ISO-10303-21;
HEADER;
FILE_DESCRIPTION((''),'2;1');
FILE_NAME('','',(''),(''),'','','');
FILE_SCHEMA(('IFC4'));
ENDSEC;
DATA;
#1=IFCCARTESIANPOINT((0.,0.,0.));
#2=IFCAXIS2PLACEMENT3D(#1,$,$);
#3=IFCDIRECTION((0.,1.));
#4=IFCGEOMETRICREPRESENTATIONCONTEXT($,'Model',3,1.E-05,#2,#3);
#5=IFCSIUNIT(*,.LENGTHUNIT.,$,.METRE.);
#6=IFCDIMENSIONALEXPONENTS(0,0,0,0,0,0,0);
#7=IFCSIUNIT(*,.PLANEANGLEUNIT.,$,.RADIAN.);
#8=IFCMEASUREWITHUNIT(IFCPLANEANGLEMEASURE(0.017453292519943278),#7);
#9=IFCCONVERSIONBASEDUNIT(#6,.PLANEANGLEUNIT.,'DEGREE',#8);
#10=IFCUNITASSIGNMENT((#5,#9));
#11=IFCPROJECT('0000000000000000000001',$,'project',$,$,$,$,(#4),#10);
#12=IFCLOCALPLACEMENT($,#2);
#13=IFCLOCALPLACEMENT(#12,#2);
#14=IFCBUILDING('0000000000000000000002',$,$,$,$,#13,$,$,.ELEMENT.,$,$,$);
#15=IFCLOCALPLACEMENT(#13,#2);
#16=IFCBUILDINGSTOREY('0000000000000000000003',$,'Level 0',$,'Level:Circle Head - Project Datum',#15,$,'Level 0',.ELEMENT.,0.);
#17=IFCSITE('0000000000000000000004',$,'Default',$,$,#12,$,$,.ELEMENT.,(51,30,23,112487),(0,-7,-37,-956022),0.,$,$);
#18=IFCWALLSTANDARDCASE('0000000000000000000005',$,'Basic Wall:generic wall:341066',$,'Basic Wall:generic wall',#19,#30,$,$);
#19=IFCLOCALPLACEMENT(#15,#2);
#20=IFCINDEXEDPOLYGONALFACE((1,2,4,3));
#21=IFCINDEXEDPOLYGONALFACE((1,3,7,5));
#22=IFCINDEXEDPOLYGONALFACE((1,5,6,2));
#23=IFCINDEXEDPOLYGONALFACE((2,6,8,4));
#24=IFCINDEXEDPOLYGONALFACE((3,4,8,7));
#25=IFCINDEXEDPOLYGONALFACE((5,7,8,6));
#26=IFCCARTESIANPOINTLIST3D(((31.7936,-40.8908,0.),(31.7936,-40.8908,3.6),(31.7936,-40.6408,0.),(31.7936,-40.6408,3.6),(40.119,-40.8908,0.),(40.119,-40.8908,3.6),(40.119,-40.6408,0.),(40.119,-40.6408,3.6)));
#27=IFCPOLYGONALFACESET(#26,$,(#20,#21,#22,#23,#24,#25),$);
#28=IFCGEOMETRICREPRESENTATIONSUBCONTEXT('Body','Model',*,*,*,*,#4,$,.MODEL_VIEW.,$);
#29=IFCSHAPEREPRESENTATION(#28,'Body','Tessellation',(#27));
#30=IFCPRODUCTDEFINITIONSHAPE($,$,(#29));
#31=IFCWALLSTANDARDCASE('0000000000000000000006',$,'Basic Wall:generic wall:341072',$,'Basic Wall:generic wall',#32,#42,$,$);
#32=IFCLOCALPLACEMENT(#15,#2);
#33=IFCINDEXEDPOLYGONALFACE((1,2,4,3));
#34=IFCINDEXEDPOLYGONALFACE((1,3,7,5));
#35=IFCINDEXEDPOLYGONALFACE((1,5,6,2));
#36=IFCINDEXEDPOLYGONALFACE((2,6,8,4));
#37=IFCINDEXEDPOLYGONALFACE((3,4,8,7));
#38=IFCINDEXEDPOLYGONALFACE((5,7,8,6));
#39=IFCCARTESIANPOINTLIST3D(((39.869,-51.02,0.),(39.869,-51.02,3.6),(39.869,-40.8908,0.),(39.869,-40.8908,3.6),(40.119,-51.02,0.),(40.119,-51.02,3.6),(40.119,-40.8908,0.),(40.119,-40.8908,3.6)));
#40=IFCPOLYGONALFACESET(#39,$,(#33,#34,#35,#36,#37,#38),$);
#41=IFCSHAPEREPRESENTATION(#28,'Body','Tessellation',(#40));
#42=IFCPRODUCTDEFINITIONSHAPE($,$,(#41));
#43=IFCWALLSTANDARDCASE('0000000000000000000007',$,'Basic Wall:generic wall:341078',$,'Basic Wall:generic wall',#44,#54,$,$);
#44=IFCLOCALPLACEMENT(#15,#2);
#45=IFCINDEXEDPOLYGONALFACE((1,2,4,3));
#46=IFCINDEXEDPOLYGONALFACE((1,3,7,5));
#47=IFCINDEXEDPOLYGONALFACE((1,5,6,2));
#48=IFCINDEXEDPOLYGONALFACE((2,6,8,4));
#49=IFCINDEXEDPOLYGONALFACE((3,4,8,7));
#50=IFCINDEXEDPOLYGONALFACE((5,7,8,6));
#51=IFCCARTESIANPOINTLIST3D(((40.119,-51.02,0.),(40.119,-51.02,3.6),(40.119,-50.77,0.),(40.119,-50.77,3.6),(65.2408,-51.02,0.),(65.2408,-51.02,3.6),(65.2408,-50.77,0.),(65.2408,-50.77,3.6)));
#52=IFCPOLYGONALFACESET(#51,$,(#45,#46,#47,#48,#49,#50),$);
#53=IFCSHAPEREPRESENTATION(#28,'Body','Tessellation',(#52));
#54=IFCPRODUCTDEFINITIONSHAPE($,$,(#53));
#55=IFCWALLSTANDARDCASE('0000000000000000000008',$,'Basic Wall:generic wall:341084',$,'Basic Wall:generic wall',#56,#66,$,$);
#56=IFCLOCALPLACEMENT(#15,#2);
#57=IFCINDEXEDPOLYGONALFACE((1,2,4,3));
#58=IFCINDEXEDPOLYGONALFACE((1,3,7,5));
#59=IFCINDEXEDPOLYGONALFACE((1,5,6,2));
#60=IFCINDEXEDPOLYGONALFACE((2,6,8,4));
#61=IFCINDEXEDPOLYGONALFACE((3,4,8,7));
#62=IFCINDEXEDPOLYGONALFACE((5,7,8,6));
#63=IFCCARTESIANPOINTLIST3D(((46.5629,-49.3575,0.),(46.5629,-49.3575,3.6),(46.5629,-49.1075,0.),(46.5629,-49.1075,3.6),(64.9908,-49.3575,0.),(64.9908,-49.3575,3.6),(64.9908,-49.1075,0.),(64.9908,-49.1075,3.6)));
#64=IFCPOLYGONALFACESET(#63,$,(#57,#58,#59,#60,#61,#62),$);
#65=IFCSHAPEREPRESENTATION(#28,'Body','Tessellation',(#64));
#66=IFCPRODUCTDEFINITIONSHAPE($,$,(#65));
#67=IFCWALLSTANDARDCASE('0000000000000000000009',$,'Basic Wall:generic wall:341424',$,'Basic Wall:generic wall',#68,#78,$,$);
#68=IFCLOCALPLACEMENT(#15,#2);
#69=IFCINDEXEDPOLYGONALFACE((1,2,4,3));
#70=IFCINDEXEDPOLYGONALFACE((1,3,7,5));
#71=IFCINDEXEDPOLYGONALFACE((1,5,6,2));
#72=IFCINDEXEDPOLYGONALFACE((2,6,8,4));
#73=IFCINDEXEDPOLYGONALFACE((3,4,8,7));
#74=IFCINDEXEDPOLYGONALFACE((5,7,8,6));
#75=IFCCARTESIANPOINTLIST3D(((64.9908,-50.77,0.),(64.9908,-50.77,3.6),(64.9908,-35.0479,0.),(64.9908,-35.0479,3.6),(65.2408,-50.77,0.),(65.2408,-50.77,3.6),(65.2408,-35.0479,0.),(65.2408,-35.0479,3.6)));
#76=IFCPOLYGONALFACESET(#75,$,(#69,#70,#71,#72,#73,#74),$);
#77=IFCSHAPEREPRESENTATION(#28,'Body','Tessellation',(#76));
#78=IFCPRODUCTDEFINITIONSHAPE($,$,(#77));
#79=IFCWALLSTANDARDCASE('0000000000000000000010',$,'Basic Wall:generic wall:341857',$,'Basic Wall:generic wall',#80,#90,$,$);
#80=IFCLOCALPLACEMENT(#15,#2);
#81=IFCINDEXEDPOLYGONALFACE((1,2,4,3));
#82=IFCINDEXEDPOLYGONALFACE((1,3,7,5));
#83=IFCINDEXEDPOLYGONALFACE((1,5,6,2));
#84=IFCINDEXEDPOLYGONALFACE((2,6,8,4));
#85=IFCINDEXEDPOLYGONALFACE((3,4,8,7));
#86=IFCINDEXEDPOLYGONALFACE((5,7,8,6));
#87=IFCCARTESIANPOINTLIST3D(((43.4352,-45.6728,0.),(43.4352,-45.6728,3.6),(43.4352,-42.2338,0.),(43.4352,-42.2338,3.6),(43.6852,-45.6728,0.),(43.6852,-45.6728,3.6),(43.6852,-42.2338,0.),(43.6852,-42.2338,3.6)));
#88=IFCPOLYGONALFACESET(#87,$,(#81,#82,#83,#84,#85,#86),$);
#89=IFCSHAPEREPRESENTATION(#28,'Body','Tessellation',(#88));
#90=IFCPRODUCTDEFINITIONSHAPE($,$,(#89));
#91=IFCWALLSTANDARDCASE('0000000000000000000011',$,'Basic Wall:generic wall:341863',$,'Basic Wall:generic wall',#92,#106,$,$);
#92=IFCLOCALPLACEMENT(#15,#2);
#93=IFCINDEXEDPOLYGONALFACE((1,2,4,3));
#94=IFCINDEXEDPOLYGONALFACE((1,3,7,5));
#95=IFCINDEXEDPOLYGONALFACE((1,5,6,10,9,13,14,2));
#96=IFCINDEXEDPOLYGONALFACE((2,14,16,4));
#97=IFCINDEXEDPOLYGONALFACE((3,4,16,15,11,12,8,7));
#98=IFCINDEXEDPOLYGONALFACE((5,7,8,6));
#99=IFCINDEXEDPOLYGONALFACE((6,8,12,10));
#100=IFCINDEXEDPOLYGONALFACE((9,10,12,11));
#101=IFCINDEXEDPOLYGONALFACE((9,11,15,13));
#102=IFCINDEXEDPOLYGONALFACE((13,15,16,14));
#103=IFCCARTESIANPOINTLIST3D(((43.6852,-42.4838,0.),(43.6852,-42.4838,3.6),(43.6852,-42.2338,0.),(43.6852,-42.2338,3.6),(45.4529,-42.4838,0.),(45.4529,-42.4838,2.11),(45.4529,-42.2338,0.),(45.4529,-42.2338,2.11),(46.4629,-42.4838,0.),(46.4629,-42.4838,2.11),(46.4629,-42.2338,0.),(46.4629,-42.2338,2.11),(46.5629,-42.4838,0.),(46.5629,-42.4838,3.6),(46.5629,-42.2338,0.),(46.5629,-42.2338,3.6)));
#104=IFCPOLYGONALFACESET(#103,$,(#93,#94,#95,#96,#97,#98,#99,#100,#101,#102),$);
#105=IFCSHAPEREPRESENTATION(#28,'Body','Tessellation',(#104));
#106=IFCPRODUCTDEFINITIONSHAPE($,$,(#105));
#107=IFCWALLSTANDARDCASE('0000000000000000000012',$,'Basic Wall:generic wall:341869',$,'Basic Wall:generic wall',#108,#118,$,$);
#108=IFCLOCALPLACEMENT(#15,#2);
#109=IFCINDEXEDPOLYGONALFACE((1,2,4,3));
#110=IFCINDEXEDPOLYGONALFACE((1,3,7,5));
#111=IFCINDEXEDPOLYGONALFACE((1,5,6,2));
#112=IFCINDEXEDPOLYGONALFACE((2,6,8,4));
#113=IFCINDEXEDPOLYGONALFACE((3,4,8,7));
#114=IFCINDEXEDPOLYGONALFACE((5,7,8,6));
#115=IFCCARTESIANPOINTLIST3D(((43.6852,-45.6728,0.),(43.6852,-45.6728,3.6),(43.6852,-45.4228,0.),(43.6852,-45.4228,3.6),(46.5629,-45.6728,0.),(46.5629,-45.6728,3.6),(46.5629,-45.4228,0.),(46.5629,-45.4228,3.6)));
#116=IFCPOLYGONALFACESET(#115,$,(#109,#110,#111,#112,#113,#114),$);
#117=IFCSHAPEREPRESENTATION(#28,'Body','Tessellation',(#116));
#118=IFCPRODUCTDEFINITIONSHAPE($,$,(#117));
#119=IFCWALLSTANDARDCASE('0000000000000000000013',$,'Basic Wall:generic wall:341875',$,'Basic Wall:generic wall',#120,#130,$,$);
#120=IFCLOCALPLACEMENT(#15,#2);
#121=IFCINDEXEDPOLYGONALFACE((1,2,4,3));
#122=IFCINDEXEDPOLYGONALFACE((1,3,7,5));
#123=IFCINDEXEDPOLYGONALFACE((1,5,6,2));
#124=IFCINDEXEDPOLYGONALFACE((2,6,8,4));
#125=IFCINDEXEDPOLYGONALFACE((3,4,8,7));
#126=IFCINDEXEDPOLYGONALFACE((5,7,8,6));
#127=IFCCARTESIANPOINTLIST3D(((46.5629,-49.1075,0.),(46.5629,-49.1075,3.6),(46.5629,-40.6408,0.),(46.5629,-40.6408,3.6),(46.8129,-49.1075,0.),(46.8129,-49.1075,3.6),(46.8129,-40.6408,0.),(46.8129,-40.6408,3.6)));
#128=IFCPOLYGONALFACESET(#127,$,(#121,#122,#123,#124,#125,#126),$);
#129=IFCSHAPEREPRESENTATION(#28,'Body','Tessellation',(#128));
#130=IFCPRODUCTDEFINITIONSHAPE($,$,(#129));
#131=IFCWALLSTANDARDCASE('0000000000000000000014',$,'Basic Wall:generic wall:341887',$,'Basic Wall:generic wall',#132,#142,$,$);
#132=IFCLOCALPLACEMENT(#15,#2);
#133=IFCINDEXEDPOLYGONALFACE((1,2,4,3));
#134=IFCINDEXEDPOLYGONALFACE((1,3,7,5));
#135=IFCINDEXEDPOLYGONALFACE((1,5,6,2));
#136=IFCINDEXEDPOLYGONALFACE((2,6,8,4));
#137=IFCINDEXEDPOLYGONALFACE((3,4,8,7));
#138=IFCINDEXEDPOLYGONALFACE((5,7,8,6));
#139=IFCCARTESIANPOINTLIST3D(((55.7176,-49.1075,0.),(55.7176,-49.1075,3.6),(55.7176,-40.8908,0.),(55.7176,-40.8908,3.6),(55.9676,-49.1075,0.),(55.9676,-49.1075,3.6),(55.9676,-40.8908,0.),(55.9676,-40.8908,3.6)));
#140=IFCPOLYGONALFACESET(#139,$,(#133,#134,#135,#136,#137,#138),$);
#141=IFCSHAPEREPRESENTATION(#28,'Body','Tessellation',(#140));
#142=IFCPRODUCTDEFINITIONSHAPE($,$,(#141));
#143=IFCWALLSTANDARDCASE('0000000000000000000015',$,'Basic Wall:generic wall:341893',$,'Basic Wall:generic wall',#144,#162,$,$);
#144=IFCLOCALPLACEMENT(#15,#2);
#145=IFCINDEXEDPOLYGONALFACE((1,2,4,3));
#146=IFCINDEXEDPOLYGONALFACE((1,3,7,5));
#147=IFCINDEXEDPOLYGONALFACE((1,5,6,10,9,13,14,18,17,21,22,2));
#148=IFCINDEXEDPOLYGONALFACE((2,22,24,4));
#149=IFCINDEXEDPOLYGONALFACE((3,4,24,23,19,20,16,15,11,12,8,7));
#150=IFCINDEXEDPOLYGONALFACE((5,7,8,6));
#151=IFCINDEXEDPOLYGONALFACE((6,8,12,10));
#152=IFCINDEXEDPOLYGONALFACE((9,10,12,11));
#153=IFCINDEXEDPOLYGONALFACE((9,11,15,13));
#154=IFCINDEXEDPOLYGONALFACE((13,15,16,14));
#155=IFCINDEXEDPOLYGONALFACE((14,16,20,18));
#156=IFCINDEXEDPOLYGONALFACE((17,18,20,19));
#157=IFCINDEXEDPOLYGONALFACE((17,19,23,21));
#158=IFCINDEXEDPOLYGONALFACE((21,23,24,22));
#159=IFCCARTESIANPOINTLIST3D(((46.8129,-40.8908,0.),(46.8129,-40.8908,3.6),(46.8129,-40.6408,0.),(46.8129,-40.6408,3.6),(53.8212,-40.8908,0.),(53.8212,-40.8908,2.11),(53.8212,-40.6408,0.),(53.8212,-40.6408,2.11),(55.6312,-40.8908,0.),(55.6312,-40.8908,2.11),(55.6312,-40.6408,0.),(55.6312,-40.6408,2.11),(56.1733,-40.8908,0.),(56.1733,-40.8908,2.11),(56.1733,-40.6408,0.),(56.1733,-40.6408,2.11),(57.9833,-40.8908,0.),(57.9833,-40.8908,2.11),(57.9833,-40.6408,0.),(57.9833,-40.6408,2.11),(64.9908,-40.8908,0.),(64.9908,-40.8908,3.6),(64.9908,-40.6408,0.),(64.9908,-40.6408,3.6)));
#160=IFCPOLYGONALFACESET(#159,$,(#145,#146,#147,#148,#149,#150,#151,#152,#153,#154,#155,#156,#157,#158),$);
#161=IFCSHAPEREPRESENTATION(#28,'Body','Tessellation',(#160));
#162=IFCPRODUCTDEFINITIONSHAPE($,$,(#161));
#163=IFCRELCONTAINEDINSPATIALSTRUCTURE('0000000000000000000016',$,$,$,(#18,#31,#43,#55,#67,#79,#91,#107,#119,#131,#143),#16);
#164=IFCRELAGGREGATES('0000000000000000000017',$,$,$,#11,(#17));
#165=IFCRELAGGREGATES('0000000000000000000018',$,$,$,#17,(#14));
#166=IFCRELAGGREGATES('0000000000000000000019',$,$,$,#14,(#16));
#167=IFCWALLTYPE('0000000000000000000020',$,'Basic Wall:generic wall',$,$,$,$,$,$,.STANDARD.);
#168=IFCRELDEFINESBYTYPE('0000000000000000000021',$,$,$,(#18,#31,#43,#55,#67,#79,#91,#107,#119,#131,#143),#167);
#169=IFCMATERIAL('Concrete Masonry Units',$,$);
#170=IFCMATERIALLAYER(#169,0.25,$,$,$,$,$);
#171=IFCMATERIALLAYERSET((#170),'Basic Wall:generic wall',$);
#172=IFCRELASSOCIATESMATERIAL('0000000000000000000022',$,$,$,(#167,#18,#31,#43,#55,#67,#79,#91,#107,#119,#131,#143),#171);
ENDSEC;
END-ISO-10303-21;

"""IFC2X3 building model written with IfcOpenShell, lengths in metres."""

from ifc_helpers import new_model, entity, si_unit, converted_unit, direction, frame, frame_2d, origin, place, context, subcontext, project, spatial, rectangle, extrude, material, layer, layer_set, layer_usage, type_object, element, save


model = new_model("IFC2X3")

# Units and contexts
model_context = context("Model", 3, precision=1e-05, world=origin(), true_north=direction((0.0, 1.0)))
body_context = subcontext(model_context, "Body", "Model", "MODEL_VIEW")
ifc_project = project(units=[si_unit("LENGTHUNIT", "METRE"), converted_unit("PLANEANGLEUNIT", "DEGREE", entity("IfcPlaneAngleMeasure", 0.017453292519943278), si_unit("PLANEANGLEUNIT", "RADIAN"), dimensions=[0, 0, 0, 0, 0, 0, 0])], contexts=[model_context])

# Site, building, storey
site_placement = place(None, origin())
site = spatial("IfcSite", under=ifc_project, at=site_placement, Name="Default", CompositionType="ELEMENT", RefLatitude=(51, 30, 23, 112487), RefLongitude=(0, -7, -37, -956022), RefElevation=0.0)
building_placement = place(site_placement, origin())
building = spatial("IfcBuilding", under=site, at=building_placement, CompositionType="ELEMENT")
storey_placement = place(building_placement, origin())
storey = spatial("IfcBuildingStorey", under=building, at=storey_placement, Name="Level 0", ObjectType="Level:Circle Head - Project Datum", LongName="Level 0", CompositionType="ELEMENT", Elevation=0.0)

# Walls
ifc_material = material(Name="Concrete Masonry Units")
ifc_layer = layer(ifc_material, 0.25)
ifc_layer_set = layer_set([ifc_layer], Name="Basic Wall:generic wall")
ifc_layer_usage_1 = layer_usage(ifc_layer_set, "AXIS2", "NEGATIVE", 0.125)
wall_type = type_object("IfcWallType", Name="Basic Wall:generic wall", PredefinedType="STANDARD", material=ifc_layer_set)
wall_1_placement = place(storey_placement, frame((31.7936, -40.7658, 0.0)))
element("IfcWallStandardCase", 1, at=wall_1_placement, inside=storey, type_object=wall_type, material=ifc_layer_usage_1, Name="Basic Wall:generic wall:341066", ObjectType="Basic Wall:generic wall", context=body_context, shape_type="SweptSolid", body=[
    extrude(rectangle(XDim=8.3254, YDim=0.25, at=frame_2d((4.1627, 0.0), x_axis=(-1.0, 0.0))), origin(), (0.0, 0.0, 1.0), 3.6),
])
ifc_layer_usage_2 = layer_usage(ifc_layer_set, "AXIS2", "NEGATIVE", 0.125)
wall_2_placement = place(storey_placement, frame((39.994, -40.8908, 0.0), z_axis=(0.0, 0.0, 1.0), x_axis=(0.0, -1.0, 0.0)))
element("IfcWallStandardCase", 2, at=wall_2_placement, inside=storey, type_object=wall_type, material=ifc_layer_usage_2, Name="Basic Wall:generic wall:341072", ObjectType="Basic Wall:generic wall", context=body_context, shape_type="SweptSolid", body=[
    extrude(rectangle(XDim=10.1292, YDim=0.25, at=frame_2d((5.0646, 0.0), x_axis=(-1.0, 0.0))), origin(), (0.0, 0.0, 1.0), 3.6),
])
ifc_layer_usage_3 = layer_usage(ifc_layer_set, "AXIS2", "NEGATIVE", 0.125)
wall_3_placement = place(storey_placement, frame((40.119, -50.895, 0.0)))
element("IfcWallStandardCase", 3, at=wall_3_placement, inside=storey, type_object=wall_type, material=ifc_layer_usage_3, Name="Basic Wall:generic wall:341078", ObjectType="Basic Wall:generic wall", context=body_context, shape_type="SweptSolid", body=[
    extrude(rectangle(XDim=25.1218, YDim=0.25, at=frame_2d((12.5609, 0.0), x_axis=(-1.0, 0.0))), origin(), (0.0, 0.0, 1.0), 3.6),
])
ifc_layer_usage_4 = layer_usage(ifc_layer_set, "AXIS2", "NEGATIVE", 0.125)
wall_4_placement = place(storey_placement, frame((64.9908, -49.2325, 0.0), z_axis=(0.0, 0.0, 1.0), x_axis=(-1.0, 0.0, 0.0)))
element("IfcWallStandardCase", 4, at=wall_4_placement, inside=storey, type_object=wall_type, material=ifc_layer_usage_4, Name="Basic Wall:generic wall:341084", ObjectType="Basic Wall:generic wall", context=body_context, shape_type="SweptSolid", body=[
    extrude(rectangle(XDim=18.4279, YDim=0.25, at=frame_2d((9.2139, 0.0), x_axis=(-1.0, 0.0))), origin(), (0.0, 0.0, 1.0), 3.6),
])
ifc_layer_usage_5 = layer_usage(ifc_layer_set, "AXIS2", "NEGATIVE", 0.125)
wall_5_placement = place(storey_placement, frame((65.1158, -50.77, 0.0), z_axis=(0.0, 0.0, 1.0), x_axis=(0.0, 1.0, 0.0)))
element("IfcWallStandardCase", 5, at=wall_5_placement, inside=storey, type_object=wall_type, material=ifc_layer_usage_5, Name="Basic Wall:generic wall:341424", ObjectType="Basic Wall:generic wall", context=body_context, shape_type="SweptSolid", body=[
    extrude(rectangle(XDim=15.7221, YDim=0.25, at=frame_2d((7.861, 0.0), x_axis=(-1.0, 0.0))), origin(), (0.0, 0.0, 1.0), 3.6),
])
ifc_layer_usage_6 = layer_usage(ifc_layer_set, "AXIS2", "NEGATIVE", 0.125)
wall_6_placement = place(storey_placement, frame((43.5602, -45.6728, 0.0), z_axis=(0.0, 0.0, 1.0), x_axis=(0.0, 1.0, 0.0)))
element("IfcWallStandardCase", 6, at=wall_6_placement, inside=storey, type_object=wall_type, material=ifc_layer_usage_6, Name="Basic Wall:generic wall:341857", ObjectType="Basic Wall:generic wall", context=body_context, shape_type="SweptSolid", body=[
    extrude(rectangle(XDim=3.4391, YDim=0.25, at=frame_2d((1.7195, 0.0), x_axis=(-1.0, 0.0))), origin(), (0.0, 0.0, 1.0), 3.6),
])

# Wall, opening
ifc_layer_usage_7 = layer_usage(ifc_layer_set, "AXIS2", "NEGATIVE", 0.125)
wall_7_placement = place(storey_placement, frame((43.6852, -42.3588, 0.0)))
wall_7 = element("IfcWallStandardCase", 7, at=wall_7_placement, inside=storey, type_object=wall_type, material=ifc_layer_usage_7, Name="Basic Wall:generic wall:341863", ObjectType="Basic Wall:generic wall", context=body_context, shape_type="SweptSolid", body=[
    extrude(rectangle(XDim=2.8776, YDim=0.25, at=frame_2d((1.4388, 0.0), x_axis=(1.0, 0.0))), origin(), (0.0, 0.0, 1.0), 3.6),
])
opening_1_placement = place(wall_7_placement, frame((2.7776, 0.125, 0.0)))
element("IfcOpeningElement", 8, at=opening_1_placement, cuts=wall_7, ObjectType="Opening", context=body_context, shape_type="SweptSolid", body=[
    extrude(rectangle(XDim=2.11, YDim=1.01, at=frame_2d((1.055, 0.505), x_axis=(1.0, 0.0))), frame((0.0, 0.0, 0.0), z_axis=(0.0, -1.0, 0.0), x_axis=(0.0, 0.0, 1.0)), (0.0, 0.0, 1.0), 0.25),
])

# Walls
ifc_layer_usage_8 = layer_usage(ifc_layer_set, "AXIS2", "NEGATIVE", 0.125)
wall_8_placement = place(storey_placement, frame((46.5629, -45.5478, 0.0), z_axis=(0.0, 0.0, 1.0), x_axis=(-1.0, 0.0, 0.0)))
element("IfcWallStandardCase", 9, at=wall_8_placement, inside=storey, type_object=wall_type, material=ifc_layer_usage_8, Name="Basic Wall:generic wall:341869", ObjectType="Basic Wall:generic wall", context=body_context, shape_type="SweptSolid", body=[
    extrude(rectangle(XDim=2.8776, YDim=0.25, at=frame_2d((1.4388, 0.0), x_axis=(-1.0, 0.0))), origin(), (0.0, 0.0, 1.0), 3.6),
])
ifc_layer_usage_9 = layer_usage(ifc_layer_set, "AXIS2", "NEGATIVE", 0.125)
wall_9_placement = place(storey_placement, frame((46.6879, -40.6408, 0.0), z_axis=(0.0, 0.0, 1.0), x_axis=(0.0, -1.0, 0.0)))
element("IfcWallStandardCase", 10, at=wall_9_placement, inside=storey, type_object=wall_type, material=ifc_layer_usage_9, Name="Basic Wall:generic wall:341875", ObjectType="Basic Wall:generic wall", context=body_context, shape_type="SweptSolid", body=[
    extrude(rectangle(XDim=8.4668, YDim=0.25, at=frame_2d((4.2334, 0.0), x_axis=(-1.0, 0.0))), origin(), (0.0, 0.0, 1.0), 3.6),
])
ifc_layer_usage_10 = layer_usage(ifc_layer_set, "AXIS2", "NEGATIVE", 0.125)
wall_10_placement = place(storey_placement, frame((55.8426, -49.1075, 0.0), z_axis=(0.0, 0.0, 1.0), x_axis=(0.0, 1.0, 0.0)))
element("IfcWallStandardCase", 11, at=wall_10_placement, inside=storey, type_object=wall_type, material=ifc_layer_usage_10, Name="Basic Wall:generic wall:341887", ObjectType="Basic Wall:generic wall", context=body_context, shape_type="SweptSolid", body=[
    extrude(rectangle(XDim=8.2168, YDim=0.25, at=frame_2d((4.1084, 0.0), x_axis=(-1.0, 0.0))), origin(), (0.0, 0.0, 1.0), 3.6),
])

# Wall, openings
ifc_layer_usage_11 = layer_usage(ifc_layer_set, "AXIS2", "NEGATIVE", 0.125)
wall_11_placement = place(storey_placement, frame((64.9908, -40.7658, 0.0), z_axis=(0.0, 0.0, 1.0), x_axis=(-1.0, 0.0, 0.0)))
wall_11 = element("IfcWallStandardCase", 12, at=wall_11_placement, inside=storey, type_object=wall_type, material=ifc_layer_usage_11, Name="Basic Wall:generic wall:341893", ObjectType="Basic Wall:generic wall", context=body_context, shape_type="SweptSolid", body=[
    extrude(rectangle(XDim=18.1779, YDim=0.25, at=frame_2d((9.0889, 0.0), x_axis=(1.0, 0.0))), origin(), (0.0, 0.0, 1.0), 3.6),
])
opening_2_placement = place(wall_11_placement, frame((7.0075, -0.125, 0.0)))
element("IfcOpeningElement", 13, at=opening_2_placement, cuts=wall_11, ObjectType="Opening", context=body_context, shape_type="SweptSolid", body=[
    extrude(rectangle(XDim=2.11, YDim=1.81, at=frame_2d((1.055, 0.905), x_axis=(-1.0, 0.0))), frame((0.0, 0.0, 0.0), z_axis=(0.0, 1.0, 0.0), x_axis=(0.0, 0.0, 1.0)), (0.0, 0.0, 1.0), 0.25),
])
opening_3_placement = place(wall_11_placement, frame((9.3596, -0.125, 0.0)))
element("IfcOpeningElement", 14, at=opening_3_placement, cuts=wall_11, ObjectType="Opening", context=body_context, shape_type="SweptSolid", body=[
    extrude(rectangle(XDim=2.11, YDim=1.81, at=frame_2d((1.055, 0.905), x_axis=(-1.0, 0.0))), frame((0.0, 0.0, 0.0), z_axis=(0.0, 1.0, 0.0), x_axis=(0.0, 0.0, 1.0)), (0.0, 0.0, 1.0), 0.25),
])

save(model, "model.ifc")
